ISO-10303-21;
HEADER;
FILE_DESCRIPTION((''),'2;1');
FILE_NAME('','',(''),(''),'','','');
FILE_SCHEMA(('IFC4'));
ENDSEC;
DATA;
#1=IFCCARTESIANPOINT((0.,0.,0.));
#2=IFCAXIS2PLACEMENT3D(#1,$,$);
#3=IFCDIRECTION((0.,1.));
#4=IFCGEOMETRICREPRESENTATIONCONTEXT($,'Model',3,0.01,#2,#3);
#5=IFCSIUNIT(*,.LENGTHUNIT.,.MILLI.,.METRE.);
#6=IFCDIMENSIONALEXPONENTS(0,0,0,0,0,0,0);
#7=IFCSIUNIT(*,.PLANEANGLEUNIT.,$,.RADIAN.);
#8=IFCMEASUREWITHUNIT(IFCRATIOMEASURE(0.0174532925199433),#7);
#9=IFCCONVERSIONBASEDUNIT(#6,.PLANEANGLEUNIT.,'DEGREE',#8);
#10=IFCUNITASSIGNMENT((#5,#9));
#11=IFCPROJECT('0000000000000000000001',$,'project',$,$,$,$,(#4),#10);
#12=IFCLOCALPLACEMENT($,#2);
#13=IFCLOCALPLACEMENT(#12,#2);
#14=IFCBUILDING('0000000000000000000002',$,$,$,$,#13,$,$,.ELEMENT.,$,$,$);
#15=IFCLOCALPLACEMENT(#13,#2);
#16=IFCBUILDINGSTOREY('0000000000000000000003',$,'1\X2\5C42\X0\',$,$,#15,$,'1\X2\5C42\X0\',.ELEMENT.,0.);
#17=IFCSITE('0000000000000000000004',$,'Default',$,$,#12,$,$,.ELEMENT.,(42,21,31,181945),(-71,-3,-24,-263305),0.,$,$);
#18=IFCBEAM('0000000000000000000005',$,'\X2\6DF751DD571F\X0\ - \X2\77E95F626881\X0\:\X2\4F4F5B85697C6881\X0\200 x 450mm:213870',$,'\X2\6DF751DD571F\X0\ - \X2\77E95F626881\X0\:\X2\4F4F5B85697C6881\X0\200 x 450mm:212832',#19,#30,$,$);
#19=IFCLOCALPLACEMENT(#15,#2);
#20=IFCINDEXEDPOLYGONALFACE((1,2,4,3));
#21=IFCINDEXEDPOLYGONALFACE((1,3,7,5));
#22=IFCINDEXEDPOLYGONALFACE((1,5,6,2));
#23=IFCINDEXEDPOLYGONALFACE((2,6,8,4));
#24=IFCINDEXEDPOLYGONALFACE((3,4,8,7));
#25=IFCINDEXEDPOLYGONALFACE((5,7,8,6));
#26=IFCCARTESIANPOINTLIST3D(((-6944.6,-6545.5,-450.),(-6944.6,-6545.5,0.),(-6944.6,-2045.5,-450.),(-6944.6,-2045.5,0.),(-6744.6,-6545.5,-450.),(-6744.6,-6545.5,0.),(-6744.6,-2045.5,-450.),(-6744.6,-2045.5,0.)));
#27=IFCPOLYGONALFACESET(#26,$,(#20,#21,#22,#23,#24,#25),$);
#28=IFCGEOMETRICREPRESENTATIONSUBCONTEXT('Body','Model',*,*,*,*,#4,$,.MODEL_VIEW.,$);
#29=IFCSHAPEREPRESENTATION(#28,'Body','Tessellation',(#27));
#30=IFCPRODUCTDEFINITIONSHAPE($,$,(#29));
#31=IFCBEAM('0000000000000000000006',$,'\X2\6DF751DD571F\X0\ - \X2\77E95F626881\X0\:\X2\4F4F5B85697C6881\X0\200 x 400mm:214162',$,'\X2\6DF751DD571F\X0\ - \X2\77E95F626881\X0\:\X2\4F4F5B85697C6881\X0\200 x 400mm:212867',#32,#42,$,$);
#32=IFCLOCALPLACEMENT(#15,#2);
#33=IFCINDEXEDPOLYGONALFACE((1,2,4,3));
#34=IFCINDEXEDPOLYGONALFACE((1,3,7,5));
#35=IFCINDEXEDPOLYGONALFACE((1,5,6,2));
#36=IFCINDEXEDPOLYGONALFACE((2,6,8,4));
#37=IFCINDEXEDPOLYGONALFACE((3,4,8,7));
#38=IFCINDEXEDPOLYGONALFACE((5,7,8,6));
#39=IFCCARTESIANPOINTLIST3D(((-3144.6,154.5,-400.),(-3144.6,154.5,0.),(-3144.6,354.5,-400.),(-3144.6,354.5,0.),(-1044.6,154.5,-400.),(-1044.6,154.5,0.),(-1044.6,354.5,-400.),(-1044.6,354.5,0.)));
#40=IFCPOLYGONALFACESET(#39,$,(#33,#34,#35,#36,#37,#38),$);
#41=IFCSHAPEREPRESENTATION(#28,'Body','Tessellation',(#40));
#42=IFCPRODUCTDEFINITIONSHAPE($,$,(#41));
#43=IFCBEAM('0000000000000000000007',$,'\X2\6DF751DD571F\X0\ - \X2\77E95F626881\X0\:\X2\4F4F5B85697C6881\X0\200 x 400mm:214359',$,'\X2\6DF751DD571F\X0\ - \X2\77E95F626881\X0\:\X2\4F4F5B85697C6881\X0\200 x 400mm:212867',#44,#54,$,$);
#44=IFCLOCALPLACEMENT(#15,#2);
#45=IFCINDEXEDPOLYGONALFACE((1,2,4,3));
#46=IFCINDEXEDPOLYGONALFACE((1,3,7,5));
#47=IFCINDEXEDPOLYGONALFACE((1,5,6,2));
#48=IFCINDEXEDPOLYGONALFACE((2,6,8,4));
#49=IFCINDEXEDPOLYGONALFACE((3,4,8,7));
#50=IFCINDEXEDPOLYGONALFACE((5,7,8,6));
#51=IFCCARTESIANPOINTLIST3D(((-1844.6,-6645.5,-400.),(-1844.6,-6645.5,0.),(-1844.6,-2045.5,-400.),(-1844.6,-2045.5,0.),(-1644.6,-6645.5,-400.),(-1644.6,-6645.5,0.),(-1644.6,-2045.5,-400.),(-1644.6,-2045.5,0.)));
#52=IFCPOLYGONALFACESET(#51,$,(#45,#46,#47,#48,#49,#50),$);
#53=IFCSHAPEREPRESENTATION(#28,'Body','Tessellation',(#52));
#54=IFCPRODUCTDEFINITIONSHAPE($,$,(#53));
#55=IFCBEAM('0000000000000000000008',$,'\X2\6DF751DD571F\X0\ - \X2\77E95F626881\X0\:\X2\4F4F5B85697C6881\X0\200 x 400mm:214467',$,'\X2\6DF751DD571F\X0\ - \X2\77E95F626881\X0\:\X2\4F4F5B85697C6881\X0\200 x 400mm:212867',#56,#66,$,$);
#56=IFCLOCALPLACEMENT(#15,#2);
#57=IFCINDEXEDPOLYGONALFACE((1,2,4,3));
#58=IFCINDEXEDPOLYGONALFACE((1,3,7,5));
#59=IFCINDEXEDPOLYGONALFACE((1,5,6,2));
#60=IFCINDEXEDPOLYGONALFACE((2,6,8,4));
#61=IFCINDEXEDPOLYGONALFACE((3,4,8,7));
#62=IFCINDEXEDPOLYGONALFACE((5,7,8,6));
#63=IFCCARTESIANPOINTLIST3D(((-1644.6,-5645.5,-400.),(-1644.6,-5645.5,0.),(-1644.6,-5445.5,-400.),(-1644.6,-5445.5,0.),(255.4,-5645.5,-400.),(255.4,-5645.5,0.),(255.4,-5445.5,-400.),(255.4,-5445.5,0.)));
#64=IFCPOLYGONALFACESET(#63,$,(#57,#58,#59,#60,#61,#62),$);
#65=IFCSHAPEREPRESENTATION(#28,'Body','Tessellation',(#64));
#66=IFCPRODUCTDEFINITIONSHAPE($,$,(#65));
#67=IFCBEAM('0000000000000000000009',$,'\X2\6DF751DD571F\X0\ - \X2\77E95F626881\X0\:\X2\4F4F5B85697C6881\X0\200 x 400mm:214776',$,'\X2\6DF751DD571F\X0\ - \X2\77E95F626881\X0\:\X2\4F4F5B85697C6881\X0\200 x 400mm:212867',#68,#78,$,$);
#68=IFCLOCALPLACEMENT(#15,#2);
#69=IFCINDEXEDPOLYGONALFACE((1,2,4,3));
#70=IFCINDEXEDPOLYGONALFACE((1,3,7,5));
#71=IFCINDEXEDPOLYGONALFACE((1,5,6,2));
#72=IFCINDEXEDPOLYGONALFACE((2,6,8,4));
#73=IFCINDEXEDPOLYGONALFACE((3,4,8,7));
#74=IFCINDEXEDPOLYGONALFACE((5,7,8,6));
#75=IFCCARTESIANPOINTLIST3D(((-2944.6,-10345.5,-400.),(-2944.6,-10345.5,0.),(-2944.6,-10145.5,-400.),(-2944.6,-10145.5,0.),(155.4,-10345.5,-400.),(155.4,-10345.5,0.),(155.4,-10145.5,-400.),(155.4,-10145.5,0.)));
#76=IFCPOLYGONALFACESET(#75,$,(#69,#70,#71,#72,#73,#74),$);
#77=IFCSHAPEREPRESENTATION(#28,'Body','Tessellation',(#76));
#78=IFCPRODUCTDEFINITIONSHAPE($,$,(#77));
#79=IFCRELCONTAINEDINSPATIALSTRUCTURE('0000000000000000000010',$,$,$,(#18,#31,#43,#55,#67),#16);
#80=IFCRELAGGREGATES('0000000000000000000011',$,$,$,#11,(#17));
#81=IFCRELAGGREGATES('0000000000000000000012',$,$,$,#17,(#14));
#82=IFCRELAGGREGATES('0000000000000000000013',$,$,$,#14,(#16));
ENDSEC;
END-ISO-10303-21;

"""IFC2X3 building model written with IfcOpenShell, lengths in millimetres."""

from ifc_helpers import new_model, entity, si_unit, converted_unit, direction, frame, frame_2d, origin, place, context, subcontext, project, spatial, rectangle, extrude, element, save


model = new_model("IFC2X3")

# Units and contexts
model_context = context("Model", 3, precision=0.01, world=origin(), true_north=direction((0.0, 1.0)))
body_context = subcontext(model_context, "Body", "Model", "MODEL_VIEW")
ifc_project = project(units=[si_unit("LENGTHUNIT", "METRE", prefix="MILLI"), converted_unit("PLANEANGLEUNIT", "DEGREE", entity("IfcRatioMeasure", 0.0174532925199433), si_unit("PLANEANGLEUNIT", "RADIAN"), dimensions=[0, 0, 0, 0, 0, 0, 0])], contexts=[model_context])

# Site, building, storey
site_placement = place(None, origin())
site = spatial("IfcSite", under=ifc_project, at=site_placement, Name="Default", CompositionType="ELEMENT", RefLatitude=(42, 21, 31, 181945), RefLongitude=(-71, -3, -24, -263305), RefElevation=0.0)
building_placement = place(site_placement, origin())
building = spatial("IfcBuilding", under=site, at=building_placement, CompositionType="ELEMENT")
storey_placement = place(building_placement, origin())
storey = spatial("IfcBuildingStorey", under=building, at=storey_placement, Name="1层", LongName="1层", CompositionType="ELEMENT", Elevation=0.0)

# Beams
beam_1_placement = place(storey_placement, frame((-6844.6, -1945.5, 0.0), z_axis=(0.0, 0.0, 1.0), x_axis=(0.0, -1.0, 0.0)))
element("IfcBeam", 1, at=beam_1_placement, inside=storey, Name="混凝土 - 矩形梁:住宅楼梁200 x 450mm:213870", ObjectType="混凝土 - 矩形梁:住宅楼梁200 x 450mm:212832", context=body_context, shape_type="SweptSolid", body=[
    extrude(rectangle(XDim=450.0, YDim=200.0, at=frame_2d((0.0, 0.0), x_axis=(1.0, 0.0))), frame((100.0, 0.0, -225.0), z_axis=(1.0, 0.0, 0.0), x_axis=(0.0, 0.0, -1.0)), (0.0, 0.0, 1.0), 4500.0),
])
beam_2_placement = place(storey_placement, frame((-3244.6, 254.5, 0.0)))
element("IfcBeam", 2, at=beam_2_placement, inside=storey, Name="混凝土 - 矩形梁:住宅楼梁200 x 400mm:214162", ObjectType="混凝土 - 矩形梁:住宅楼梁200 x 400mm:212867", context=body_context, shape_type="SweptSolid", body=[
    extrude(rectangle(XDim=400.0, YDim=200.0, at=frame_2d((0.0, 0.0), x_axis=(1.0, 0.0))), frame((100.0, 0.0, -200.0), z_axis=(1.0, 0.0, 0.0), x_axis=(0.0, 0.0, -1.0)), (0.0, 0.0, 1.0), 2100.0),
])
beam_3_placement = place(storey_placement, frame((-1744.6, -1945.5, 0.0), z_axis=(0.0, 0.0, 1.0), x_axis=(0.0, -1.0, 0.0)))
element("IfcBeam", 3, at=beam_3_placement, inside=storey, Name="混凝土 - 矩形梁:住宅楼梁200 x 400mm:214359", ObjectType="混凝土 - 矩形梁:住宅楼梁200 x 400mm:212867", context=body_context, shape_type="SweptSolid", body=[
    extrude(rectangle(XDim=400.0, YDim=200.0, at=frame_2d((0.0, 0.0), x_axis=(1.0, 0.0))), frame((100.0, 0.0, -200.0), z_axis=(1.0, 0.0, 0.0), x_axis=(0.0, 0.0, -1.0)), (0.0, 0.0, 1.0), 4600.0),
])
beam_4_placement = place(storey_placement, frame((-1744.6, -5545.5, 0.0)))
element("IfcBeam", 4, at=beam_4_placement, inside=storey, Name="混凝土 - 矩形梁:住宅楼梁200 x 400mm:214467", ObjectType="混凝土 - 矩形梁:住宅楼梁200 x 400mm:212867", context=body_context, shape_type="SweptSolid", body=[
    extrude(rectangle(XDim=400.0, YDim=200.0, at=frame_2d((0.0, 0.0), x_axis=(1.0, 0.0))), frame((100.0, 0.0, -200.0), z_axis=(1.0, 0.0, 0.0), x_axis=(0.0, 0.0, -1.0)), (0.0, 0.0, 1.0), 1900.0),
])
beam_5_placement = place(storey_placement, frame((-2944.6, -10245.5, 0.0)))
element("IfcBeam", 5, at=beam_5_placement, inside=storey, Name="混凝土 - 矩形梁:住宅楼梁200 x 400mm:214776", ObjectType="混凝土 - 矩形梁:住宅楼梁200 x 400mm:212867", context=body_context, shape_type="SweptSolid", body=[
    extrude(rectangle(XDim=400.0, YDim=200.0, at=frame_2d((0.0, 0.0), x_axis=(1.0, 0.0))), frame((0.0, 0.0, -200.0), z_axis=(1.0, 0.0, 0.0), x_axis=(0.0, 0.0, -1.0)), (0.0, 0.0, 1.0), 3100.0),
])

save(model, "model.ifc")
